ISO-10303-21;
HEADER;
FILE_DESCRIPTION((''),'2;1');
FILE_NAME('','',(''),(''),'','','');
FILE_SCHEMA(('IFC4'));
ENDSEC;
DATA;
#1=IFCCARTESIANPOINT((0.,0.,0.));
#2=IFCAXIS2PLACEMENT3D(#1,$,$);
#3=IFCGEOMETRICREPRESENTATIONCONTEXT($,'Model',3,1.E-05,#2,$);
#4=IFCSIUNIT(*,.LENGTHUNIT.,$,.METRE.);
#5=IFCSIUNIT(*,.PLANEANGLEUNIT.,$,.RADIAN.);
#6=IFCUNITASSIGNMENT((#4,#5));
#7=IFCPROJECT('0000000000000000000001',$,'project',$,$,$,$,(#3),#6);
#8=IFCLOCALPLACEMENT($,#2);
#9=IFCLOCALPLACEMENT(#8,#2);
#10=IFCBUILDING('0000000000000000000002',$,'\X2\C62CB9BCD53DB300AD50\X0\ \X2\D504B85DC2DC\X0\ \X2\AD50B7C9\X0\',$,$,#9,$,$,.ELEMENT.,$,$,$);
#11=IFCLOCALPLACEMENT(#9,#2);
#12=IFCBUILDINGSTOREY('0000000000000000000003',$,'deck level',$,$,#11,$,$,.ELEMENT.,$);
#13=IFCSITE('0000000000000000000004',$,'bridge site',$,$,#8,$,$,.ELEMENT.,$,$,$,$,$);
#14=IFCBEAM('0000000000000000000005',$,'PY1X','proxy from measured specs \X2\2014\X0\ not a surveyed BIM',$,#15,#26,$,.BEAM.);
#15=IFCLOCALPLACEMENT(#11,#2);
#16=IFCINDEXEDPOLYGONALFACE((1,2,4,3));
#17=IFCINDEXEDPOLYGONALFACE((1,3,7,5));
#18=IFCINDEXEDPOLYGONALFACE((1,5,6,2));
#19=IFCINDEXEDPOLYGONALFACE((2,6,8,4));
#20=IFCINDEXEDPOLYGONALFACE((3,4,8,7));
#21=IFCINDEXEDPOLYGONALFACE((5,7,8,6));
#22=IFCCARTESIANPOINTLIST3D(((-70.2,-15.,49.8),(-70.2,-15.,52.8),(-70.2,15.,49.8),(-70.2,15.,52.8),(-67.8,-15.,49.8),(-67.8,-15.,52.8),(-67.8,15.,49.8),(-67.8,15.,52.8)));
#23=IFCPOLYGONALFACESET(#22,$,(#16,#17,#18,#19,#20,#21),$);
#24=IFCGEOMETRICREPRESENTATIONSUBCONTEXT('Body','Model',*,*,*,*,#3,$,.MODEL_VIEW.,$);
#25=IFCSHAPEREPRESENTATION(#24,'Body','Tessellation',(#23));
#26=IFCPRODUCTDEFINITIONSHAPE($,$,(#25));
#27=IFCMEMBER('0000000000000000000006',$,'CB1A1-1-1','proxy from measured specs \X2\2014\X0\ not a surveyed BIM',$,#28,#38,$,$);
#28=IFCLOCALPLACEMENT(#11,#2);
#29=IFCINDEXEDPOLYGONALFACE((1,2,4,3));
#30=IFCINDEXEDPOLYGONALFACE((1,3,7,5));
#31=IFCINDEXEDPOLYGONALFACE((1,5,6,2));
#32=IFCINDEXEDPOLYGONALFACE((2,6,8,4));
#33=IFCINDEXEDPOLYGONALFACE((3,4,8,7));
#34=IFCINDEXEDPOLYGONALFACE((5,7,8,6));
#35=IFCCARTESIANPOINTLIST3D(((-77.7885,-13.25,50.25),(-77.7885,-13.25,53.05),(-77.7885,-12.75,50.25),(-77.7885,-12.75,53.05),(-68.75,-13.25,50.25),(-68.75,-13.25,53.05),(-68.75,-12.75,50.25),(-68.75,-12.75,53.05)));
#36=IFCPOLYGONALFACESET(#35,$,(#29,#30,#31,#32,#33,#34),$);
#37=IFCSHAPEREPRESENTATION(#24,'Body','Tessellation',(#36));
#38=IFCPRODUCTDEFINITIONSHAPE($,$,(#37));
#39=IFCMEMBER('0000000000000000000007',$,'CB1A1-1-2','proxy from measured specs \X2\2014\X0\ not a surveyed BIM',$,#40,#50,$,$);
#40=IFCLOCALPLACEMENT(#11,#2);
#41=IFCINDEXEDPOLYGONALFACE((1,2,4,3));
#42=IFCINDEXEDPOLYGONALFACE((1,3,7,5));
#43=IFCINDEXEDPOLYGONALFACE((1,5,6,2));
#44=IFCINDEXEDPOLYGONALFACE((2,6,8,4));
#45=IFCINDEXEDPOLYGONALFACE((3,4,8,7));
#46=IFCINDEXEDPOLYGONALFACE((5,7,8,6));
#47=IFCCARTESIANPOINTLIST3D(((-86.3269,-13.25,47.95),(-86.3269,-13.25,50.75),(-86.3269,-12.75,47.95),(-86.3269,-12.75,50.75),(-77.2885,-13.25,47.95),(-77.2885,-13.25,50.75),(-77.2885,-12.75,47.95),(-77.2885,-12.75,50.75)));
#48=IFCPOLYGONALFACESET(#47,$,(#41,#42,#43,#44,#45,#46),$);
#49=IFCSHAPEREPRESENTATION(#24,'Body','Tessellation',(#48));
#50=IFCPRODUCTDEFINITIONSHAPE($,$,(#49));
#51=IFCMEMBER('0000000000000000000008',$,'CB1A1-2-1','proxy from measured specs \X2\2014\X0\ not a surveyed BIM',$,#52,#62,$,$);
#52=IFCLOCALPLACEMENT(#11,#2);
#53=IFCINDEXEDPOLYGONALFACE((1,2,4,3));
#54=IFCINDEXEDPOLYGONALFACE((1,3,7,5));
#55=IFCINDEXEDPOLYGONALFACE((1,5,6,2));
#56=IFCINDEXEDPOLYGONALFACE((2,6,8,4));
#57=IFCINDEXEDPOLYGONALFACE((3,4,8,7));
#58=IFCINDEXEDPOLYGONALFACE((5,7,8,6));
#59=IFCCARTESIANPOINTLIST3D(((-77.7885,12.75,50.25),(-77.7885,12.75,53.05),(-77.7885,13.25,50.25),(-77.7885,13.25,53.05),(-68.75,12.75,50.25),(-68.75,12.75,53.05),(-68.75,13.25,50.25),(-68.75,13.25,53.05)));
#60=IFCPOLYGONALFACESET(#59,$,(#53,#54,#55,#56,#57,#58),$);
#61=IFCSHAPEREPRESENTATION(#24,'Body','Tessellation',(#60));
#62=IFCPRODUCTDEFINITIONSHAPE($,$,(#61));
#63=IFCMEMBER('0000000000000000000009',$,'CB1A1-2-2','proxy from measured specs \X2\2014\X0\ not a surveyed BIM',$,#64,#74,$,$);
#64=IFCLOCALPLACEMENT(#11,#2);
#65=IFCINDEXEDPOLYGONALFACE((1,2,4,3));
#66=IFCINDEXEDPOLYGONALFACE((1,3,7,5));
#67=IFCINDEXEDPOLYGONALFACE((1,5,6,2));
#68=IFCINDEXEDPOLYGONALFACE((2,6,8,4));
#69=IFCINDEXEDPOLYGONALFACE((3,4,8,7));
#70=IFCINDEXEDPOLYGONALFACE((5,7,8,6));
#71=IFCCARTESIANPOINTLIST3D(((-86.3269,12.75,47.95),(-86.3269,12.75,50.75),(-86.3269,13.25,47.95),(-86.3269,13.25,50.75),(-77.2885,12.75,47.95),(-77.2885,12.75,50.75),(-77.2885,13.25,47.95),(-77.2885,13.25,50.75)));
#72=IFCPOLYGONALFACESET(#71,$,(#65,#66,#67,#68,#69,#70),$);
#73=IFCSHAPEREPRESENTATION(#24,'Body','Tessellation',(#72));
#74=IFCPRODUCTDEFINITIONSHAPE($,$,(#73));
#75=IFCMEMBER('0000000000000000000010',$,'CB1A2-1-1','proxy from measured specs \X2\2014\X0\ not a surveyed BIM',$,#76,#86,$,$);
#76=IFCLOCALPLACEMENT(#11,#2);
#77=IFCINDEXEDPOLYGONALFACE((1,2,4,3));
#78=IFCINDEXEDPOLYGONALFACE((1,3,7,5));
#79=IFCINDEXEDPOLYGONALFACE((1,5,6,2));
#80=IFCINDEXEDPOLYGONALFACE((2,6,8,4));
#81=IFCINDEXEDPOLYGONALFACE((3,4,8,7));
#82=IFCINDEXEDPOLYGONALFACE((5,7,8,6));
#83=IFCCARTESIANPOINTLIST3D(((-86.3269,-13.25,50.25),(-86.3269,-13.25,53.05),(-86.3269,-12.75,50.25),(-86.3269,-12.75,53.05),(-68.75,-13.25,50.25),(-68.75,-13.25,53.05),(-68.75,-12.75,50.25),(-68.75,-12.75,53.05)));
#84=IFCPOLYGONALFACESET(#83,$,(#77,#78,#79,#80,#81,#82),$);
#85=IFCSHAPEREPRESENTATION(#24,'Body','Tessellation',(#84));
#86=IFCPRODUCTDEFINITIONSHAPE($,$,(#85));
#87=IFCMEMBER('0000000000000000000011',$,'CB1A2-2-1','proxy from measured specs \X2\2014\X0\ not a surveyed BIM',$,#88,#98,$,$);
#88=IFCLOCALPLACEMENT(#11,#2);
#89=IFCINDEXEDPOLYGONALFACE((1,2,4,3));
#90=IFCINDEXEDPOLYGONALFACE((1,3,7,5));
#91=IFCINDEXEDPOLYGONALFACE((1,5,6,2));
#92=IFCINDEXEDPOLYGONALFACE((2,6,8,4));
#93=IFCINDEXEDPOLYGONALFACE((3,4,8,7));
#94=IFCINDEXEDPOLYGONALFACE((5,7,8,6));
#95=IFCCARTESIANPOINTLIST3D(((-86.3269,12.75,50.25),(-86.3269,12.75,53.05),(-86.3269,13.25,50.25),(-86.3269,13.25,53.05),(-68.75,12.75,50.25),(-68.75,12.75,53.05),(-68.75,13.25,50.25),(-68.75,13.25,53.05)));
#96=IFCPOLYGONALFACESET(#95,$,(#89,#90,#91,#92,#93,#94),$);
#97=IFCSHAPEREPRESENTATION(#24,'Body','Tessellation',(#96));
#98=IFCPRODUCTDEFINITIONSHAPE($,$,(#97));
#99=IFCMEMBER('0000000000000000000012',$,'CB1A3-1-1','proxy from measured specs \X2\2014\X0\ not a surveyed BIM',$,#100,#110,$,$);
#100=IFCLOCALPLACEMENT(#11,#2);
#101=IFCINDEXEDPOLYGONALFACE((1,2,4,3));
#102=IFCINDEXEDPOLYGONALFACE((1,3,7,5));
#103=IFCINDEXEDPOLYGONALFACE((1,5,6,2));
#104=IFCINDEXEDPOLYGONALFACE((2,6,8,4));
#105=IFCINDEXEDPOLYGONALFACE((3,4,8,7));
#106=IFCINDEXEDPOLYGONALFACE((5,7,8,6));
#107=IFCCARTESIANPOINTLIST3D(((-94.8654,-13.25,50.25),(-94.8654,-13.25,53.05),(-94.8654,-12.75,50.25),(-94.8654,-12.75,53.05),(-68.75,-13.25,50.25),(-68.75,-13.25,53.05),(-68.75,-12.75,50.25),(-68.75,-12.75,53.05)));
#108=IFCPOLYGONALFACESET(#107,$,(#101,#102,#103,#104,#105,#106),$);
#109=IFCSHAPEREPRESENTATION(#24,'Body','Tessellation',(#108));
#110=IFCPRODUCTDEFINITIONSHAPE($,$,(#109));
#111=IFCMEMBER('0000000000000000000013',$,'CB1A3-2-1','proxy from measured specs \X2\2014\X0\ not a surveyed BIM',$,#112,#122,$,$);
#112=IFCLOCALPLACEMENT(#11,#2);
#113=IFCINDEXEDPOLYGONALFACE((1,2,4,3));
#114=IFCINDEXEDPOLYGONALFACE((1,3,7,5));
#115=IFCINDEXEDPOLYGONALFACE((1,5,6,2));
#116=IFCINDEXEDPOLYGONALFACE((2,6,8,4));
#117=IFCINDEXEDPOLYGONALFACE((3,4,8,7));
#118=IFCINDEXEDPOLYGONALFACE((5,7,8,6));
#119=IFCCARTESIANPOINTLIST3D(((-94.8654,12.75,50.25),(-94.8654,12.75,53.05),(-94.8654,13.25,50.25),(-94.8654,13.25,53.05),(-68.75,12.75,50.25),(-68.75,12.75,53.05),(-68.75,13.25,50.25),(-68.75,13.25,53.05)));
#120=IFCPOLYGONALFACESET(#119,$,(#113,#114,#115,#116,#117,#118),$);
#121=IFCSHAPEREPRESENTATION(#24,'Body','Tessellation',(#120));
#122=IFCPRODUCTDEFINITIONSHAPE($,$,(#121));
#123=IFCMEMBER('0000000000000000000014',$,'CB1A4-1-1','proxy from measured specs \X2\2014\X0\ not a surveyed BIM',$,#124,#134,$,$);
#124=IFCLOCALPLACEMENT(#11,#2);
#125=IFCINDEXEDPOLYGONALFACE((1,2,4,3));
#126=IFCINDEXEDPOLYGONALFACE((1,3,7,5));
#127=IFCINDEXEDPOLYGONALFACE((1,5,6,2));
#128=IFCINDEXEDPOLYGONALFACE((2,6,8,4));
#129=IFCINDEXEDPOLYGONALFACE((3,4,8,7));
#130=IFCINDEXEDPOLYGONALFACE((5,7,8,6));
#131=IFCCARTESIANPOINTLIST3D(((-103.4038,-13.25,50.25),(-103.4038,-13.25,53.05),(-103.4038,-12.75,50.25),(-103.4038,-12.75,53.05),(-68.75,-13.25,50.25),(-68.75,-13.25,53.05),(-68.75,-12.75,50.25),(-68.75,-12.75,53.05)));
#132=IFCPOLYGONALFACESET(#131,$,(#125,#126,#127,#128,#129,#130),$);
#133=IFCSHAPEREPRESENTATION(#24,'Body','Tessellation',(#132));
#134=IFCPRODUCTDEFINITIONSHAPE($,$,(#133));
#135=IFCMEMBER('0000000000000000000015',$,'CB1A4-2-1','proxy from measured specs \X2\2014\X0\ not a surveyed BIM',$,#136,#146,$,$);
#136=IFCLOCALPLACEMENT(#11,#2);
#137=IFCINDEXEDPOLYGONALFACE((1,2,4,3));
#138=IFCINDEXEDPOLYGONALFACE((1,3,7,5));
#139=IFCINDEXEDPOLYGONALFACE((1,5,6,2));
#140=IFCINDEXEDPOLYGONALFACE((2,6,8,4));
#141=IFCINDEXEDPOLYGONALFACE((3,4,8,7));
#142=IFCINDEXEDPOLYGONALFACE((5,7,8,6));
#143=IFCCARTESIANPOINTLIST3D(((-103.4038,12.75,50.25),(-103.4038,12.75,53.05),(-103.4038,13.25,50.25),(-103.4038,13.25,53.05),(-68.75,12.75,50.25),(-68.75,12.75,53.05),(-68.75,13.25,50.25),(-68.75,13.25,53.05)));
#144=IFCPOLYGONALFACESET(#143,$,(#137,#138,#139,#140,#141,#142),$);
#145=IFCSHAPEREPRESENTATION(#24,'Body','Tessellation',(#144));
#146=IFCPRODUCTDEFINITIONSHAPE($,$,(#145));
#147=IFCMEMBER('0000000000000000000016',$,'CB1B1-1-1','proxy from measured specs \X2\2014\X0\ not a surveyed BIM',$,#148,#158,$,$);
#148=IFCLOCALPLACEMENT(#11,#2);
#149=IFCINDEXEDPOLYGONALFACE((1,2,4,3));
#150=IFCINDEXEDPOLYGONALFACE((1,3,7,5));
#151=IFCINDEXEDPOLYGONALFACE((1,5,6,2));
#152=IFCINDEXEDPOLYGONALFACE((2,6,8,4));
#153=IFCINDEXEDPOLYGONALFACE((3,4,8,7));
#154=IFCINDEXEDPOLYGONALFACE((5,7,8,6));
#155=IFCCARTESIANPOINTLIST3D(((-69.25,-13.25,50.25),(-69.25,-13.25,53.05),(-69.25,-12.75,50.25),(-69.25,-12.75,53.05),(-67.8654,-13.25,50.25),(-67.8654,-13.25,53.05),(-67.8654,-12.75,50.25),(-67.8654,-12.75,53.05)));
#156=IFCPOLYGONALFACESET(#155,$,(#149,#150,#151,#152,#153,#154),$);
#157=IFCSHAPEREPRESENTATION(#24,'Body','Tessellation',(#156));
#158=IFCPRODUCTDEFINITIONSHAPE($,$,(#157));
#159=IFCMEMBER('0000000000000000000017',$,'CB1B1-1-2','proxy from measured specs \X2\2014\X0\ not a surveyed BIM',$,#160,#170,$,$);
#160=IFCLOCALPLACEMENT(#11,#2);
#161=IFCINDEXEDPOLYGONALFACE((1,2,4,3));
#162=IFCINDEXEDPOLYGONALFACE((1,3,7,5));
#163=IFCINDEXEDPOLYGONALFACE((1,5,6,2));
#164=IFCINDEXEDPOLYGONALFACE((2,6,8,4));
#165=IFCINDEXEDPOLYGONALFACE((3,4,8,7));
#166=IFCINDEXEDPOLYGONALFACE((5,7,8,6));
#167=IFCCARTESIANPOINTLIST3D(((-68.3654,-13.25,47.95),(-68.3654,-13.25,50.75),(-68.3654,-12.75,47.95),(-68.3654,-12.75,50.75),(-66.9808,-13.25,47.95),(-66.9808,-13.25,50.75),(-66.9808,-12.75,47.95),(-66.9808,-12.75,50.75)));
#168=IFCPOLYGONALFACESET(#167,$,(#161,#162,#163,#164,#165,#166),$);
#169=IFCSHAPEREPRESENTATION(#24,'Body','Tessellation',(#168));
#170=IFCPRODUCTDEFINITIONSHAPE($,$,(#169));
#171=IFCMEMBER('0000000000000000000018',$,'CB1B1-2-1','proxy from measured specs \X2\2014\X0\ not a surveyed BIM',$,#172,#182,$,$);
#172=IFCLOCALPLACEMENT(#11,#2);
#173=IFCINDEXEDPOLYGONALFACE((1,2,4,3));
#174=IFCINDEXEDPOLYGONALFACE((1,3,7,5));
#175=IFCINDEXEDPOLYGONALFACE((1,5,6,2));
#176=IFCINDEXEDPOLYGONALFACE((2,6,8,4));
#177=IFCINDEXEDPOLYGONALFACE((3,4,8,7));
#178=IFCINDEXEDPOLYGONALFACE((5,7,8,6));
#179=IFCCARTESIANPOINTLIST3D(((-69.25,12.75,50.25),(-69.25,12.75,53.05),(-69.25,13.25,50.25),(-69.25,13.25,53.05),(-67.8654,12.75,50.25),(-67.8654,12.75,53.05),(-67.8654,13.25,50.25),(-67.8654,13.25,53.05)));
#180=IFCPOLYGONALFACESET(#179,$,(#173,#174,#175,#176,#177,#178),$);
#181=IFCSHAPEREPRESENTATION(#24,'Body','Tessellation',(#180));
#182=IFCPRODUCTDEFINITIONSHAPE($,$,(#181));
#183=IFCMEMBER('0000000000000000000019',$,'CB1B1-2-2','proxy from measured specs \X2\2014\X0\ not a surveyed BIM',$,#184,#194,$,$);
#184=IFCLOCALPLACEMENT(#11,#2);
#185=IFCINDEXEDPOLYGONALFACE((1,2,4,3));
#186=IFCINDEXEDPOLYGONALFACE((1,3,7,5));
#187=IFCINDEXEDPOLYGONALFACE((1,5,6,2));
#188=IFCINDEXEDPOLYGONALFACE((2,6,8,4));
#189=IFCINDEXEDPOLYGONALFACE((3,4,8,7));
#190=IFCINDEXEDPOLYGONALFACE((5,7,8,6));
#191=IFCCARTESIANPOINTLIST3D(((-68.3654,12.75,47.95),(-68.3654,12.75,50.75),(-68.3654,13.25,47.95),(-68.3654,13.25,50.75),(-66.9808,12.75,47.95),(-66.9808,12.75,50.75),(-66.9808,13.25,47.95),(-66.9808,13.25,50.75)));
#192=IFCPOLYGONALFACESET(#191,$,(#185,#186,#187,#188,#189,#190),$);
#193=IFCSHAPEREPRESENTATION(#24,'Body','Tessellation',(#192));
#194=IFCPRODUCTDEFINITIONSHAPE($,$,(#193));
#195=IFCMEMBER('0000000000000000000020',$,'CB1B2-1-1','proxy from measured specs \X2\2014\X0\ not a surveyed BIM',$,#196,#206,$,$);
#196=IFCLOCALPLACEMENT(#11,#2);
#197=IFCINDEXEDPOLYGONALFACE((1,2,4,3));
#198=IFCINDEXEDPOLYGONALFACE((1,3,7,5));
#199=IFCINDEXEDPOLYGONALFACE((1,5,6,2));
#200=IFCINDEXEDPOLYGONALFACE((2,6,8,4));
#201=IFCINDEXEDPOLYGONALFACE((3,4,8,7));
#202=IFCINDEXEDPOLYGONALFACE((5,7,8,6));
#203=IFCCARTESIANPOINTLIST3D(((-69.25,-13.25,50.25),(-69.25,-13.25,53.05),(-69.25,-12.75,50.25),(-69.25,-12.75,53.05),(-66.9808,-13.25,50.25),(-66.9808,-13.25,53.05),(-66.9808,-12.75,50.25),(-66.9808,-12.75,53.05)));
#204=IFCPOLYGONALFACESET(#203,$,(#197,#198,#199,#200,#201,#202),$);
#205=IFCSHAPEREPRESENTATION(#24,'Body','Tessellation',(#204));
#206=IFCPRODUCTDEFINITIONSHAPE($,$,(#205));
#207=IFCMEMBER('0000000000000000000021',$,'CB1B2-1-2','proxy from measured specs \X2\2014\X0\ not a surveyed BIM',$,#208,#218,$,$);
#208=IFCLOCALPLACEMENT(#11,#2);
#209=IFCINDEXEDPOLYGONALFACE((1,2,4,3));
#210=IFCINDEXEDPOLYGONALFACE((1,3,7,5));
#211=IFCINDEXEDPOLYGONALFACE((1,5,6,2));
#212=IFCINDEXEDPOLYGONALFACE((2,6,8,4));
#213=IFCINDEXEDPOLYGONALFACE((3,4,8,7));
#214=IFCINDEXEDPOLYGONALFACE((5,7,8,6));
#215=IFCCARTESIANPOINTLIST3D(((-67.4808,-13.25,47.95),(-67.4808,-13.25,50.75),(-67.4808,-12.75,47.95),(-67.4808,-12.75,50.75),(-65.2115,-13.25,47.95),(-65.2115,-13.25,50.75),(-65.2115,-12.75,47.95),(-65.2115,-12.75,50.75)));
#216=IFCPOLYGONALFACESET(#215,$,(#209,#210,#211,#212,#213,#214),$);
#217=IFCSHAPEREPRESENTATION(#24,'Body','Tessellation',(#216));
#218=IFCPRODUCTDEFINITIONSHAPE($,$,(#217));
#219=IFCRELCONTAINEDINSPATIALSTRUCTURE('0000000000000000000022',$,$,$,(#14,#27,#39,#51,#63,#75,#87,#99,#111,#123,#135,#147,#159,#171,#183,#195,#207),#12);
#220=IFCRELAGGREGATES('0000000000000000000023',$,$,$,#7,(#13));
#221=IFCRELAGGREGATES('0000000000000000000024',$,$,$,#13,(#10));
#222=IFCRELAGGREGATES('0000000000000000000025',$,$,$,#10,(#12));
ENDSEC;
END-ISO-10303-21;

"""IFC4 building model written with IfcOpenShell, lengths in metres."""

from ifc_helpers import new_model, si_unit, frame, origin, origin_2d, place, context, subcontext, project, spatial, rectangle, extrude, element, save


model = new_model("IFC4")

# Units and contexts
model_context = context("Model", 3, precision=1e-05, world=origin())
body_context = subcontext(model_context, "Body", "Model", "MODEL_VIEW")
ifc_project = project(units=[si_unit("LENGTHUNIT", "METRE"), si_unit("PLANEANGLEUNIT", "RADIAN")], contexts=[model_context])

# Site, building, storey
site_placement = place(None, origin())
site = spatial("IfcSite", under=ifc_project, at=site_placement, Name="bridge site", CompositionType="ELEMENT")
building_placement = place(site_placement, origin())
building = spatial("IfcBuilding", under=site, at=building_placement, Name="올림픽대교 프록시 교량", CompositionType="ELEMENT")
storey_placement = place(building_placement, origin())
storey = spatial("IfcBuildingStorey", under=building, at=storey_placement, Name="deck level", CompositionType="ELEMENT")

# Beam
beam_placement = place(storey_placement, frame((-69.0, 0.0, 49.8)))
element("IfcBeam", 1, at=beam_placement, inside=storey, Name="PY1X", Description="proxy from measured specs — not a surveyed BIM", PredefinedType="BEAM", context=body_context, shape_type="SweptSolid", body=[
    extrude(rectangle(XDim=2.4, YDim=30.0, at=origin_2d()), origin(), (0.0, 0.0, 1.0), 3.0),
])

# Members
member_1_placement = place(storey_placement, frame((-73.2692, -13.0, 50.25)))
element("IfcMember", 2, at=member_1_placement, inside=storey, Name="CB1A1-1-1", Description="proxy from measured specs — not a surveyed BIM", context=body_context, shape_type="SweptSolid", body=[
    extrude(rectangle(XDim=9.0385, YDim=0.5, at=origin_2d()), origin(), (0.0, 0.0, 1.0), 2.8),
])
member_2_placement = place(storey_placement, frame((-81.8077, -13.0, 47.95)))
element("IfcMember", 3, at=member_2_placement, inside=storey, Name="CB1A1-1-2", Description="proxy from measured specs — not a surveyed BIM", context=body_context, shape_type="SweptSolid", body=[
    extrude(rectangle(XDim=9.0385, YDim=0.5, at=origin_2d()), origin(), (0.0, 0.0, 1.0), 2.8),
])
member_3_placement = place(storey_placement, frame((-73.2692, 13.0, 50.25)))
element("IfcMember", 4, at=member_3_placement, inside=storey, Name="CB1A1-2-1", Description="proxy from measured specs — not a surveyed BIM", context=body_context, shape_type="SweptSolid", body=[
    extrude(rectangle(XDim=9.0385, YDim=0.5, at=origin_2d()), origin(), (0.0, 0.0, 1.0), 2.8),
])
member_4_placement = place(storey_placement, frame((-81.8077, 13.0, 47.95)))
element("IfcMember", 5, at=member_4_placement, inside=storey, Name="CB1A1-2-2", Description="proxy from measured specs — not a surveyed BIM", context=body_context, shape_type="SweptSolid", body=[
    extrude(rectangle(XDim=9.0385, YDim=0.5, at=origin_2d()), origin(), (0.0, 0.0, 1.0), 2.8),
])
for number, where, name in (
    (6, (-77.5385, -13.0, 50.25), "CB1A2-1-1"),
    (7, (-77.5385, 13.0, 50.25), "CB1A2-2-1"),
):
    element("IfcMember", number, at=place(storey_placement, frame(where)), inside=storey, Name=name, Description="proxy from measured specs — not a surveyed BIM", context=body_context, shape_type="SweptSolid", body=[
        extrude(rectangle(XDim=17.5769, YDim=0.5, at=origin_2d()), origin(), (0.0, 0.0, 1.0), 2.8),
    ])
for number, where, name in (
    (8, (-81.8077, -13.0, 50.25), "CB1A3-1-1"),
    (9, (-81.8077, 13.0, 50.25), "CB1A3-2-1"),
):
    element("IfcMember", number, at=place(storey_placement, frame(where)), inside=storey, Name=name, Description="proxy from measured specs — not a surveyed BIM", context=body_context, shape_type="SweptSolid", body=[
        extrude(rectangle(XDim=26.1154, YDim=0.5, at=origin_2d()), origin(), (0.0, 0.0, 1.0), 2.8),
    ])
for number, where, name in (
    (10, (-86.0769, -13.0, 50.25), "CB1A4-1-1"),
    (11, (-86.0769, 13.0, 50.25), "CB1A4-2-1"),
):
    element("IfcMember", number, at=place(storey_placement, frame(where)), inside=storey, Name=name, Description="proxy from measured specs — not a surveyed BIM", context=body_context, shape_type="SweptSolid", body=[
        extrude(rectangle(XDim=34.6538, YDim=0.5, at=origin_2d()), origin(), (0.0, 0.0, 1.0), 2.8),
    ])
member_5_placement = place(storey_placement, frame((-68.5577, -13.0, 50.25)))
element("IfcMember", 12, at=member_5_placement, inside=storey, Name="CB1B1-1-1", Description="proxy from measured specs — not a surveyed BIM", context=body_context, shape_type="SweptSolid", body=[
    extrude(rectangle(XDim=1.3846, YDim=0.5, at=origin_2d()), origin(), (0.0, 0.0, 1.0), 2.8),
])
member_6_placement = place(storey_placement, frame((-67.6731, -13.0, 47.95)))
element("IfcMember", 13, at=member_6_placement, inside=storey, Name="CB1B1-1-2", Description="proxy from measured specs — not a surveyed BIM", context=body_context, shape_type="SweptSolid", body=[
    extrude(rectangle(XDim=1.3846, YDim=0.5, at=origin_2d()), origin(), (0.0, 0.0, 1.0), 2.8),
])
member_7_placement = place(storey_placement, frame((-68.5577, 13.0, 50.25)))
element("IfcMember", 14, at=member_7_placement, inside=storey, Name="CB1B1-2-1", Description="proxy from measured specs — not a surveyed BIM", context=body_context, shape_type="SweptSolid", body=[
    extrude(rectangle(XDim=1.3846, YDim=0.5, at=origin_2d()), origin(), (0.0, 0.0, 1.0), 2.8),
])
member_8_placement = place(storey_placement, frame((-67.6731, 13.0, 47.95)))
element("IfcMember", 15, at=member_8_placement, inside=storey, Name="CB1B1-2-2", Description="proxy from measured specs — not a surveyed BIM", context=body_context, shape_type="SweptSolid", body=[
    extrude(rectangle(XDim=1.3846, YDim=0.5, at=origin_2d()), origin(), (0.0, 0.0, 1.0), 2.8),
])
member_9_placement = place(storey_placement, frame((-68.1154, -13.0, 50.25)))
element("IfcMember", 16, at=member_9_placement, inside=storey, Name="CB1B2-1-1", Description="proxy from measured specs — not a surveyed BIM", context=body_context, shape_type="SweptSolid", body=[
    extrude(rectangle(XDim=2.2692, YDim=0.5, at=origin_2d()), origin(), (0.0, 0.0, 1.0), 2.8),
])
member_10_placement = place(storey_placement, frame((-66.3462, -13.0, 47.95)))
element("IfcMember", 17, at=member_10_placement, inside=storey, Name="CB1B2-1-2", Description="proxy from measured specs — not a surveyed BIM", context=body_context, shape_type="SweptSolid", body=[
    extrude(rectangle(XDim=2.2692, YDim=0.5, at=origin_2d()), origin(), (0.0, 0.0, 1.0), 2.8),
])

save(model, "model.ifc")
